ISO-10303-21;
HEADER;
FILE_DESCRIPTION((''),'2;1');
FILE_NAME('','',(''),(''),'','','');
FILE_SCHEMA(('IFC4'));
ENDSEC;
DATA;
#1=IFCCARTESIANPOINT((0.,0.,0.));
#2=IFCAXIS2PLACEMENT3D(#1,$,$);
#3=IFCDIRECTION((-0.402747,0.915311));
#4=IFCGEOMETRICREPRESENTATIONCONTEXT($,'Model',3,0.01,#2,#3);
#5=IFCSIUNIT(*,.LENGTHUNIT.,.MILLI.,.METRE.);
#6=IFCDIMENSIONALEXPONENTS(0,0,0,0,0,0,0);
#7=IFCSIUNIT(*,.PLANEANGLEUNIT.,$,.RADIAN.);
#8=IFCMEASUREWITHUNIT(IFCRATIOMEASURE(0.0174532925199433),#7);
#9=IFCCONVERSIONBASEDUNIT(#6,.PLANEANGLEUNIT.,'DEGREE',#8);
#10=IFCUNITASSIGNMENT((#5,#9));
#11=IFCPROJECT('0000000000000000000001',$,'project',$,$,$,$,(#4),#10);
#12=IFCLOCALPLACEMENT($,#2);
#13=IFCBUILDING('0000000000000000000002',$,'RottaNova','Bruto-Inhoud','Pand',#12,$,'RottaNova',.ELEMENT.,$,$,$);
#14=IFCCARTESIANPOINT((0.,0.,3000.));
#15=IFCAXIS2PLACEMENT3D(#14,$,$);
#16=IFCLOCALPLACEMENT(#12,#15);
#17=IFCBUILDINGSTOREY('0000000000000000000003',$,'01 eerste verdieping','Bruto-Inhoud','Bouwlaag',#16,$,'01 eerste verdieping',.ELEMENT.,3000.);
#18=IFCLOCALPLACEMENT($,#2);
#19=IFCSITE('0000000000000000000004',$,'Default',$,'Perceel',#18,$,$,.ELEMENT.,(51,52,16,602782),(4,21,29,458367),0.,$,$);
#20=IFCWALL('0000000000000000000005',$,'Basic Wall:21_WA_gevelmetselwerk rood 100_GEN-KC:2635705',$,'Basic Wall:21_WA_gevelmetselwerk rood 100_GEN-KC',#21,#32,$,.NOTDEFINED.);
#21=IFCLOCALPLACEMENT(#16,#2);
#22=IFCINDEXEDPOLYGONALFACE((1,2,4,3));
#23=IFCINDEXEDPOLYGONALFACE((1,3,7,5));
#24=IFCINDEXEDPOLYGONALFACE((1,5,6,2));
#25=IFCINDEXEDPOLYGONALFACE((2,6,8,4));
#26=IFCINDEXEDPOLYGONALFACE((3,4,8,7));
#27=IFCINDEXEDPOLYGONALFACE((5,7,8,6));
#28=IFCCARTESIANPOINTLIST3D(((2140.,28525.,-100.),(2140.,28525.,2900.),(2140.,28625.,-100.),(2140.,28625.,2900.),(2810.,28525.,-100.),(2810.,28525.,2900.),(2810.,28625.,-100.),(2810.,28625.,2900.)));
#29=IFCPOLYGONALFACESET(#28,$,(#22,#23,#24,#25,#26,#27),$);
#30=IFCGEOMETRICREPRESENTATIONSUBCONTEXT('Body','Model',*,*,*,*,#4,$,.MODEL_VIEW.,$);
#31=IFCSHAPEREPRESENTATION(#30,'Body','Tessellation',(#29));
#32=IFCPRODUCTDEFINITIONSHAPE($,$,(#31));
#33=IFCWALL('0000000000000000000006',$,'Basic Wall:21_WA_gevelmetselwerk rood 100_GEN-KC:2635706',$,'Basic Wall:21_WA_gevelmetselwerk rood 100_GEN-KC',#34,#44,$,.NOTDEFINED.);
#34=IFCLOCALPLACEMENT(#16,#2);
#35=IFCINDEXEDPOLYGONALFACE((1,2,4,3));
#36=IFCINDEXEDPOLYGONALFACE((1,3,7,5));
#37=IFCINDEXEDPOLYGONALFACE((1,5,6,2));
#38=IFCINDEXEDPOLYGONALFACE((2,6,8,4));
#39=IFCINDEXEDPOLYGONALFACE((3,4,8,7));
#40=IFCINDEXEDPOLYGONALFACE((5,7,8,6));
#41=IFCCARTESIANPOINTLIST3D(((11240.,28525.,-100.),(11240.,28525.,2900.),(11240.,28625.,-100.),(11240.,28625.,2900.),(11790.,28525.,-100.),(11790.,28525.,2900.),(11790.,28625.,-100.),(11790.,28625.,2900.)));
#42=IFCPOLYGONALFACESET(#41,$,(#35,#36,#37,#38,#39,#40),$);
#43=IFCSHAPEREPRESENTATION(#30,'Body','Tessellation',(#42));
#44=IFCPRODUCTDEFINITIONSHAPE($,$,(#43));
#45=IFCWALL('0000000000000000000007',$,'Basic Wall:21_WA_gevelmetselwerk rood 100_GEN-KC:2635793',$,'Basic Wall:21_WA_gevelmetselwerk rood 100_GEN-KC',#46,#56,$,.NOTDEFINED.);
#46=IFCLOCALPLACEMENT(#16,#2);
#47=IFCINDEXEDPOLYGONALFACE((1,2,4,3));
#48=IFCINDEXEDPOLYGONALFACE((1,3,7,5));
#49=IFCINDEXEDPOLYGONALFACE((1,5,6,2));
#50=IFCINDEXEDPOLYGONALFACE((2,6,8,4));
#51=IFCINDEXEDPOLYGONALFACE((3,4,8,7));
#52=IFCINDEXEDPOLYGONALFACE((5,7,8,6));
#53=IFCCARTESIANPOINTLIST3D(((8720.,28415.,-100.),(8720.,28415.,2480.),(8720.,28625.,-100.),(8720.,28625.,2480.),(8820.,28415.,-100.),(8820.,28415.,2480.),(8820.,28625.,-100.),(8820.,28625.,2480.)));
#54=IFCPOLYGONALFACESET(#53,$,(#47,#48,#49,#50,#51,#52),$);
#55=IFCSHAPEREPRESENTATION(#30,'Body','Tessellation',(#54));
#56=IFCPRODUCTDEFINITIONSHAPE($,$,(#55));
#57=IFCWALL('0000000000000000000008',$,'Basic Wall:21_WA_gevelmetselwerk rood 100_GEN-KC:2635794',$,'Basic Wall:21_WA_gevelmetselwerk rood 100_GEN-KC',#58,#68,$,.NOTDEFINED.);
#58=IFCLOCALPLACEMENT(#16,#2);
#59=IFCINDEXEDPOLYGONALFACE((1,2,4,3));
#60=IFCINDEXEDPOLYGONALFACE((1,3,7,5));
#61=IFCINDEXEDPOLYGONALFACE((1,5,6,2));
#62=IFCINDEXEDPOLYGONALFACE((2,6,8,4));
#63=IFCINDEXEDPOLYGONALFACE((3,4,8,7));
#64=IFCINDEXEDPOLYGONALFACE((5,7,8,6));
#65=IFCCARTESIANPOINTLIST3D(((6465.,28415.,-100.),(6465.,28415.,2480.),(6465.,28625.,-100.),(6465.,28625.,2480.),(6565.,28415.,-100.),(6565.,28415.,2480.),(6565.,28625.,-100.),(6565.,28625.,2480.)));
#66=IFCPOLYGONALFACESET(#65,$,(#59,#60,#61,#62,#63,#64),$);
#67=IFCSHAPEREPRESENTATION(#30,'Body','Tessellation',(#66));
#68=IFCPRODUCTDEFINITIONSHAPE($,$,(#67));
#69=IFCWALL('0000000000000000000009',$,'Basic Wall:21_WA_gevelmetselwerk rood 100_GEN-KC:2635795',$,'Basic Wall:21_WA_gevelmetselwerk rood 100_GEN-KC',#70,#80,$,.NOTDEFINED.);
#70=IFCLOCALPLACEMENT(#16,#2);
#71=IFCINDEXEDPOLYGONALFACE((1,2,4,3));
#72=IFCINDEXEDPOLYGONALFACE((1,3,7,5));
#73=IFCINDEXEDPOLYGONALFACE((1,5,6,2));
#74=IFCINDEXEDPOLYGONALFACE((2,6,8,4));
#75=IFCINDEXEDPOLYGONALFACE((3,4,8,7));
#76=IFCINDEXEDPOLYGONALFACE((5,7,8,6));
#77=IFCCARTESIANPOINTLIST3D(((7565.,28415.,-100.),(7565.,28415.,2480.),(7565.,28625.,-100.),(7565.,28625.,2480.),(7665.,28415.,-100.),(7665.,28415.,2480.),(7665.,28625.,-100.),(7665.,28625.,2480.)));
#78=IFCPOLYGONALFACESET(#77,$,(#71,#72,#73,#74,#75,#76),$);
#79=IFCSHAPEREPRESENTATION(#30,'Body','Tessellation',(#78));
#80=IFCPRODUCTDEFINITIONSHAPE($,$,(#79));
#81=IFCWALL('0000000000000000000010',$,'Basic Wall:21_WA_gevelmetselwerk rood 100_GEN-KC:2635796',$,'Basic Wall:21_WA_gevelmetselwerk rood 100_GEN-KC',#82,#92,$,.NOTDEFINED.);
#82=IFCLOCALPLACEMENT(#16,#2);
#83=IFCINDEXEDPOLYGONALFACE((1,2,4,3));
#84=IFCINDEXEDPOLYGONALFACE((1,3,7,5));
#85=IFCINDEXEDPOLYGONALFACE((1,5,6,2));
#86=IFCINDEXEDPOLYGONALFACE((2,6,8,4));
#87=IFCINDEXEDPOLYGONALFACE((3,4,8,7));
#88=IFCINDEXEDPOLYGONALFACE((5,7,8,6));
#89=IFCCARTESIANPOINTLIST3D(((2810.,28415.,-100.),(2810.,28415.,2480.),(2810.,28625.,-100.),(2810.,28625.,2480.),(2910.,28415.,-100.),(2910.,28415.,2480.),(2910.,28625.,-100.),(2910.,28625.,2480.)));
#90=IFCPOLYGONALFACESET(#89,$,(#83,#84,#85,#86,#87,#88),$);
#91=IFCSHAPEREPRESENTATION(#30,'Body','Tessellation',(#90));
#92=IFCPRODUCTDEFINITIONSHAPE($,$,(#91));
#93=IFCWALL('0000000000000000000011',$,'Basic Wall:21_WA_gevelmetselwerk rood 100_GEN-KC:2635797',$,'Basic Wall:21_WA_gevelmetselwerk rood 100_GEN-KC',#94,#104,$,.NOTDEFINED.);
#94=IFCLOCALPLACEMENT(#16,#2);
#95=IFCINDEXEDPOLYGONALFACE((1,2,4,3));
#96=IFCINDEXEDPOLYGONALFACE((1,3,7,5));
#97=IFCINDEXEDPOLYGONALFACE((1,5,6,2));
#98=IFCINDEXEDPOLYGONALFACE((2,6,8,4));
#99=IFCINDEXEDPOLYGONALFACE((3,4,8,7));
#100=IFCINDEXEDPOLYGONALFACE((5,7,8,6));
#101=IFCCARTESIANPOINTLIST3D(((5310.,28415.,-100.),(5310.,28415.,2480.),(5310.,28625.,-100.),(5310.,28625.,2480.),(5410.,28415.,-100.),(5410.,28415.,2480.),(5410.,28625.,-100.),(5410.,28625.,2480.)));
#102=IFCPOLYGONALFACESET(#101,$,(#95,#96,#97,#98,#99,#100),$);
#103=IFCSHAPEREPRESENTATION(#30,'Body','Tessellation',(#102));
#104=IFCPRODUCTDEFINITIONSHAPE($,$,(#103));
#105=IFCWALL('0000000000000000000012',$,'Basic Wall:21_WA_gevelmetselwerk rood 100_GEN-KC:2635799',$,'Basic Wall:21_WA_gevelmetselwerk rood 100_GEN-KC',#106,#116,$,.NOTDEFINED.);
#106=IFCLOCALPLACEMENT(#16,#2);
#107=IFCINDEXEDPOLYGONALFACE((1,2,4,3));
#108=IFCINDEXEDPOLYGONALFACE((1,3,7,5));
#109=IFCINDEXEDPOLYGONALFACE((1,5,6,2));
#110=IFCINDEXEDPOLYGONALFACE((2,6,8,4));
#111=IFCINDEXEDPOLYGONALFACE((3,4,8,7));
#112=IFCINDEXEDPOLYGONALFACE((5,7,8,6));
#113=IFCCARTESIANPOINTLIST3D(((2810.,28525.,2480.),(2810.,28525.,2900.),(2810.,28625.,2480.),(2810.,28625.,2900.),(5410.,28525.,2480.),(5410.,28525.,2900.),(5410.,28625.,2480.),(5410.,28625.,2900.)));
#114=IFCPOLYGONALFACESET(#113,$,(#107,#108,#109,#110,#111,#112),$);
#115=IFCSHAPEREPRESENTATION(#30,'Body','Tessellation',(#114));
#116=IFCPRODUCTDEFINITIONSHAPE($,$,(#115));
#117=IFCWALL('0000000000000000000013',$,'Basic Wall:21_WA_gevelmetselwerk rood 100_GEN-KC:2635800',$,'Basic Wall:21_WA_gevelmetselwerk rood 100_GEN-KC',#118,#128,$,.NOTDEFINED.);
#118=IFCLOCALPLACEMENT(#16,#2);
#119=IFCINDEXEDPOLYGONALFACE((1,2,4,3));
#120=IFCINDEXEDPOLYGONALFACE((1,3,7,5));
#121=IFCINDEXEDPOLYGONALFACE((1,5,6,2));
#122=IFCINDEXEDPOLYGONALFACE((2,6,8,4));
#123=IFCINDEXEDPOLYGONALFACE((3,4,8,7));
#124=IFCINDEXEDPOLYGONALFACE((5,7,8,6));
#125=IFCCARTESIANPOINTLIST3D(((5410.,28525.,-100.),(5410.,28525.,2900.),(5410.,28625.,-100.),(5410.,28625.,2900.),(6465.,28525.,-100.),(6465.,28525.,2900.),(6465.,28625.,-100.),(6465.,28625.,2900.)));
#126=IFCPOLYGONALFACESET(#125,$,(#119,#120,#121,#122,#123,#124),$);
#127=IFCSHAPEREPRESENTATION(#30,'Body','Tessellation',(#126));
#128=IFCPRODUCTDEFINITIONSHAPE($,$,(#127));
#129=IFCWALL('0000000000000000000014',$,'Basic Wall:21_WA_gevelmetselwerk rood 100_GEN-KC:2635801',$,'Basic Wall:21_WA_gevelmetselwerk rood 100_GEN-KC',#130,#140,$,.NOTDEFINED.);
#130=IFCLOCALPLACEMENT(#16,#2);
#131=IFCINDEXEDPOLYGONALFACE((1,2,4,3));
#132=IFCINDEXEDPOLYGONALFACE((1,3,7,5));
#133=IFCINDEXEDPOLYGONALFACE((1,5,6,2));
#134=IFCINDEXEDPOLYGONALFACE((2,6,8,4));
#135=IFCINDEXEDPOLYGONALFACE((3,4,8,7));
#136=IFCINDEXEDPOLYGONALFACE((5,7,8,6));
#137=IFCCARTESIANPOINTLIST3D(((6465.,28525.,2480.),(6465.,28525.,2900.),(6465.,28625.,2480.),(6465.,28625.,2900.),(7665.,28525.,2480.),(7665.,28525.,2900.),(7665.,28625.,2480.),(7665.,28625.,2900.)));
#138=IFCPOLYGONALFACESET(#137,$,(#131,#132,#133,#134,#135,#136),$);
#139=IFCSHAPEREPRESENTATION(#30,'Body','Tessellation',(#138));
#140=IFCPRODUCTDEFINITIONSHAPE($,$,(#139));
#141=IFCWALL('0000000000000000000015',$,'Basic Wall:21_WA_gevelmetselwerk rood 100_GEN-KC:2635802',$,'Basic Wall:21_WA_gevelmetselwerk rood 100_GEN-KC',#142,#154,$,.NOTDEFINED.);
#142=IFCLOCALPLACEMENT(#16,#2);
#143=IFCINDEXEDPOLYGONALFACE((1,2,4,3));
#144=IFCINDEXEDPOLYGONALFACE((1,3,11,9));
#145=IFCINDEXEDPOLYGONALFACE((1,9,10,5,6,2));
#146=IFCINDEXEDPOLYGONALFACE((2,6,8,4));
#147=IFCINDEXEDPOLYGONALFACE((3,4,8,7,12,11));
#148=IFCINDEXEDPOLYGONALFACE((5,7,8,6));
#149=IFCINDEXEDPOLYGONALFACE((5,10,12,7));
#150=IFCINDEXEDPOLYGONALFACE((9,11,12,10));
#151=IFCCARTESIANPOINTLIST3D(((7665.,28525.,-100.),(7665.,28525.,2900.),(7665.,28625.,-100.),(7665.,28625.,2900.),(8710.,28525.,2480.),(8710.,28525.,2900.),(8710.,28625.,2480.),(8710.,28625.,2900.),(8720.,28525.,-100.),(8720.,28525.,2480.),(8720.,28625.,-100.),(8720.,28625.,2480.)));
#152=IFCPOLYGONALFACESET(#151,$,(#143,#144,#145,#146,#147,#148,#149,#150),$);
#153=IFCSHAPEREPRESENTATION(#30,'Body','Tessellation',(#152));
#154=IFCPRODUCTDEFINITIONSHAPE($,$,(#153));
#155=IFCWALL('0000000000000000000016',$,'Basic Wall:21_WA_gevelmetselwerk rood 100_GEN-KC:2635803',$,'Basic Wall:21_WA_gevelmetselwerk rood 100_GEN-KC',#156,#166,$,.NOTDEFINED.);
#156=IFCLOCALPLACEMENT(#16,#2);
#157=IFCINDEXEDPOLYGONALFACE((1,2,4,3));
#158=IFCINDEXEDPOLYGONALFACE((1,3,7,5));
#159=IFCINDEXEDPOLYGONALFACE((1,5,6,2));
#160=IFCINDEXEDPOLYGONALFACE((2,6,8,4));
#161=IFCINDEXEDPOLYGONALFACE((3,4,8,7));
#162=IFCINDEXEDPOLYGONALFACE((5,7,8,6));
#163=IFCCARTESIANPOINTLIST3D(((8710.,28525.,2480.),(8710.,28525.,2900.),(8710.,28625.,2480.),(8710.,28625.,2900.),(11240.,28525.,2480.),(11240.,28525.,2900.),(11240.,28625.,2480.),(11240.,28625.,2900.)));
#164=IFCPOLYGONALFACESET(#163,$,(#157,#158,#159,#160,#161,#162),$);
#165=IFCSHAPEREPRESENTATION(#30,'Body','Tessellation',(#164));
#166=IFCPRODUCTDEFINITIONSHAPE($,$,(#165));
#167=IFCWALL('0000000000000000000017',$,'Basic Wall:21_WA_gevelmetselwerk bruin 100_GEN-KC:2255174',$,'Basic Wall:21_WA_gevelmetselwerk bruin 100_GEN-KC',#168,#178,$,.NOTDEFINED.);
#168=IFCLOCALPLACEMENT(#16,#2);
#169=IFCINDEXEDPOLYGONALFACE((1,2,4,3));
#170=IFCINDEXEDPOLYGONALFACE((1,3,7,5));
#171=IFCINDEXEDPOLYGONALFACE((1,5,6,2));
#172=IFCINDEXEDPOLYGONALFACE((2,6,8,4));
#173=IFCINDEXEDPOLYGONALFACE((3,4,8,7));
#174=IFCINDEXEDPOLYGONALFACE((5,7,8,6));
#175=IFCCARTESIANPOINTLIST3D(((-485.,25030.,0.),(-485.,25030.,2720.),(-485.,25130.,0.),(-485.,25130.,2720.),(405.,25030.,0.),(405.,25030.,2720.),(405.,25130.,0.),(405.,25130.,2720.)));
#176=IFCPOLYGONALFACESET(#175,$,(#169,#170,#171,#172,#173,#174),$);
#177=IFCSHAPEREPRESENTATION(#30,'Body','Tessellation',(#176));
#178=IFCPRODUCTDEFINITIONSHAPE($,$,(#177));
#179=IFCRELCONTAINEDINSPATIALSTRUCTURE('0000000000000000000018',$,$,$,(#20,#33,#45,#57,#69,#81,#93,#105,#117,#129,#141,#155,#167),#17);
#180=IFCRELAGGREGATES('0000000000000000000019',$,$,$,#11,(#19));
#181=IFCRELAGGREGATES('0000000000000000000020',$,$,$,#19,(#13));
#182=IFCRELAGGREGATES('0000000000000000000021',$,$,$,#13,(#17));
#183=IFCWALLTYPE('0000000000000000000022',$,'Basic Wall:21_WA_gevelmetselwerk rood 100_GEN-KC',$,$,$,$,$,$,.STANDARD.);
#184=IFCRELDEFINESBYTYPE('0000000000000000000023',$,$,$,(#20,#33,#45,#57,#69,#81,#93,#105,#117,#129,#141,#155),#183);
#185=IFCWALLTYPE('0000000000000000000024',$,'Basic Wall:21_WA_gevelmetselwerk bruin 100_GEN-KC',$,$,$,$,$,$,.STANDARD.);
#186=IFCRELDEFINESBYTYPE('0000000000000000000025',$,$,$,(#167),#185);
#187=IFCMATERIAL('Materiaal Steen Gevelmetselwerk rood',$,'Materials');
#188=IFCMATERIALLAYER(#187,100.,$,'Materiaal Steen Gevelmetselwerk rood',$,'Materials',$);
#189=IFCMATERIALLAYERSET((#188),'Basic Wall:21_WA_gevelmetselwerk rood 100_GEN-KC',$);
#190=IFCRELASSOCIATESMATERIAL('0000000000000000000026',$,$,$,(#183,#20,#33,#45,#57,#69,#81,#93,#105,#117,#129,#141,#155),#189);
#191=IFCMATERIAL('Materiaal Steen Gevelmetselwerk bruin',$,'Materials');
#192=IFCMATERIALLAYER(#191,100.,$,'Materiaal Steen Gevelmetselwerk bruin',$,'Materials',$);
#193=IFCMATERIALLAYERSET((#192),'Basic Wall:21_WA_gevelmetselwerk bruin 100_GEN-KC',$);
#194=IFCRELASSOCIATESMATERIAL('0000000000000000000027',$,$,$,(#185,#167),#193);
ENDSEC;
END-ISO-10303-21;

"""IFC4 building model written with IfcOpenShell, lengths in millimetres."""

from ifc_helpers import new_model, entity, si_unit, converted_unit, direction, frame, frame_2d, origin, place, context, subcontext, project, spatial, polyline, rectangle, extrude, clip, bounded_halfspace, material, layer, layer_set, type_object, element, save


model = new_model("IFC4")

# Units and contexts
model_context = context("Model", 3, precision=0.01, world=origin(), true_north=direction((-0.402747, 0.915311)))
body_context = subcontext(model_context, "Body", "Model", "MODEL_VIEW")
ifc_project = project(units=[si_unit("LENGTHUNIT", "METRE", prefix="MILLI"), converted_unit("PLANEANGLEUNIT", "DEGREE", entity("IfcRatioMeasure", 0.0174532925199433), si_unit("PLANEANGLEUNIT", "RADIAN"), dimensions=[0, 0, 0, 0, 0, 0, 0])], contexts=[model_context])

# Site, building, storey
site_placement = place(None, origin())
site = spatial("IfcSite", under=ifc_project, at=site_placement, Name="Default", ObjectType="Perceel", CompositionType="ELEMENT", RefLatitude=(51, 52, 16, 602782), RefLongitude=(4, 21, 29, 458367), RefElevation=0.0)
building_placement = place(None, origin())
building = spatial("IfcBuilding", under=site, at=building_placement, Name="RottaNova", Description="Bruto-Inhoud", ObjectType="Pand", LongName="RottaNova", CompositionType="ELEMENT")
storey_placement = place(building_placement, frame((0.0, 0.0, 3000.0)))
storey = spatial("IfcBuildingStorey", under=building, at=storey_placement, Name="01 eerste verdieping", Description="Bruto-Inhoud", ObjectType="Bouwlaag", LongName="01 eerste verdieping", CompositionType="ELEMENT", Elevation=3000.0)

# Walls
ifc_material_1 = material(Name="Materiaal Steen Gevelmetselwerk rood", Category="Materials")
ifc_layer_1 = layer(ifc_material_1, 100.0, Name="Materiaal Steen Gevelmetselwerk rood", Category="Materials")
ifc_layer_set_1 = layer_set([ifc_layer_1], Name="Basic Wall:21_WA_gevelmetselwerk rood 100_GEN-KC")
wall_type_1 = type_object("IfcWallType", Name="Basic Wall:21_WA_gevelmetselwerk rood 100_GEN-KC", PredefinedType="STANDARD", material=ifc_layer_set_1)
wall_1_placement = place(storey_placement, frame((2140.0, 28575.0, -100.0)))
element("IfcWall", 1, at=wall_1_placement, inside=storey, type_object=wall_type_1, material=ifc_layer_set_1, Name="Basic Wall:21_WA_gevelmetselwerk rood 100_GEN-KC:2635705", ObjectType="Basic Wall:21_WA_gevelmetselwerk rood 100_GEN-KC", PredefinedType="NOTDEFINED", context=body_context, shape_type="SweptSolid", body=[
    extrude(rectangle(XDim=670.0, YDim=100.0, at=frame_2d((335.0, 0.0), x_axis=(-1.0, 0.0))), origin(), (0.0, 0.0, 1.0), 3000.0),
])
wall_2_placement = place(storey_placement, frame((11240.0, 28575.0, -100.0)))
element("IfcWall", 2, at=wall_2_placement, inside=storey, type_object=wall_type_1, material=ifc_layer_set_1, Name="Basic Wall:21_WA_gevelmetselwerk rood 100_GEN-KC:2635706", ObjectType="Basic Wall:21_WA_gevelmetselwerk rood 100_GEN-KC", PredefinedType="NOTDEFINED", context=body_context, shape_type="SweptSolid", body=[
    extrude(rectangle(XDim=550.0, YDim=100.0, at=frame_2d((275.0, 0.0), x_axis=(-1.0, 0.0))), origin(), (0.0, 0.0, 1.0), 3000.0),
])
wall_3_placement = place(storey_placement, frame((8770.0, 28415.0, -100.0), z_axis=(0.0, 0.0, 1.0), x_axis=(0.0, 1.0, 0.0)))
element("IfcWall", 3, at=wall_3_placement, inside=storey, type_object=wall_type_1, material=ifc_layer_set_1, Name="Basic Wall:21_WA_gevelmetselwerk rood 100_GEN-KC:2635793", ObjectType="Basic Wall:21_WA_gevelmetselwerk rood 100_GEN-KC", PredefinedType="NOTDEFINED", context=body_context, shape_type="SweptSolid", body=[
    extrude(rectangle(XDim=210.0, YDim=100.0, at=frame_2d((105.0, 0.0), x_axis=(-1.0, 0.0))), origin(), (0.0, 0.0, 1.0), 2580.0),
])
for number, where, z_axis, x_axis, name in (
    (4, (6515.0, 28415.0, -100.0), (0.0, 0.0, 1.0), (0.0, 1.0, 0.0), "Basic Wall:21_WA_gevelmetselwerk rood 100_GEN-KC:2635794"),
    (5, (7615.0, 28415.0, -100.0), (0.0, 0.0, 1.0), (0.0, 1.0, 0.0), "Basic Wall:21_WA_gevelmetselwerk rood 100_GEN-KC:2635795"),
):
    element("IfcWall", number, at=place(storey_placement, frame(where, z_axis=z_axis, x_axis=x_axis)), inside=storey, type_object=wall_type_1, material=ifc_layer_set_1, Name=name, ObjectType="Basic Wall:21_WA_gevelmetselwerk rood 100_GEN-KC", PredefinedType="NOTDEFINED", context=body_context, shape_type="SweptSolid", body=[
        extrude(rectangle(XDim=210.0, YDim=100.0, at=frame_2d((105.0, 0.0), x_axis=(-1.0, 0.0))), origin(), (0.0, 0.0, 1.0), 2580.0),
    ])
wall_4_placement = place(storey_placement, frame((2860.0, 28415.0, -100.0), z_axis=(0.0, 0.0, 1.0), x_axis=(0.0, 1.0, 0.0)))
element("IfcWall", 6, at=wall_4_placement, inside=storey, type_object=wall_type_1, material=ifc_layer_set_1, Name="Basic Wall:21_WA_gevelmetselwerk rood 100_GEN-KC:2635796", ObjectType="Basic Wall:21_WA_gevelmetselwerk rood 100_GEN-KC", PredefinedType="NOTDEFINED", context=body_context, shape_type="SweptSolid", body=[
    extrude(rectangle(XDim=210.0, YDim=100.0, at=frame_2d((105.0, 0.0), x_axis=(-1.0, 0.0))), origin(), (0.0, 0.0, 1.0), 2580.0),
])
wall_5_placement = place(storey_placement, frame((5360.0, 28415.0, -100.0), z_axis=(0.0, 0.0, 1.0), x_axis=(0.0, 1.0, 0.0)))
element("IfcWall", 7, at=wall_5_placement, inside=storey, type_object=wall_type_1, material=ifc_layer_set_1, Name="Basic Wall:21_WA_gevelmetselwerk rood 100_GEN-KC:2635797", ObjectType="Basic Wall:21_WA_gevelmetselwerk rood 100_GEN-KC", PredefinedType="NOTDEFINED", context=body_context, shape_type="SweptSolid", body=[
    extrude(rectangle(XDim=210.0, YDim=100.0, at=frame_2d((105.0, 0.0), x_axis=(-1.0, 0.0))), origin(), (0.0, 0.0, 1.0), 2580.0),
])
wall_6_placement = place(storey_placement, frame((2810.0, 28575.0, 2480.0)))
element("IfcWall", 8, at=wall_6_placement, inside=storey, type_object=wall_type_1, material=ifc_layer_set_1, Name="Basic Wall:21_WA_gevelmetselwerk rood 100_GEN-KC:2635799", ObjectType="Basic Wall:21_WA_gevelmetselwerk rood 100_GEN-KC", PredefinedType="NOTDEFINED", context=body_context, shape_type="Clipping", body=[
    clip(extrude(rectangle(XDim=2600.0, YDim=100.0, at=frame_2d((1300.0, 0.0), x_axis=(-1.0, 0.0))), origin(), (0.0, 0.0, 1.0), 420.0), bounded_halfspace(frame((2600.0, -50.0, 420.0), z_axis=(1.0, 0.0, 0.0), x_axis=(0.0, 1.0, 0.0)), False, frame((2600.0, -50.0, 420.0), z_axis=(1.0, 0.0, 0.0), x_axis=(0.0, 1.0, 0.0)), polyline([(0.0, 0.0), (0.0, -128016.0), (30480.0, -128016.0), (30480.0, 0.0), (0.0, 0.0)]))),
])
wall_7_placement = place(storey_placement, frame((5410.0, 28575.0, -100.0)))
element("IfcWall", 9, at=wall_7_placement, inside=storey, type_object=wall_type_1, material=ifc_layer_set_1, Name="Basic Wall:21_WA_gevelmetselwerk rood 100_GEN-KC:2635800", ObjectType="Basic Wall:21_WA_gevelmetselwerk rood 100_GEN-KC", PredefinedType="NOTDEFINED", context=body_context, shape_type="SweptSolid", body=[
    extrude(rectangle(XDim=1055.0, YDim=100.0, at=frame_2d((527.5, 0.0), x_axis=(-1.0, 0.0))), origin(), (0.0, 0.0, 1.0), 3000.0),
])
wall_8_placement = place(storey_placement, frame((6465.0, 28575.0, 2480.0)))
element("IfcWall", 10, at=wall_8_placement, inside=storey, type_object=wall_type_1, material=ifc_layer_set_1, Name="Basic Wall:21_WA_gevelmetselwerk rood 100_GEN-KC:2635801", ObjectType="Basic Wall:21_WA_gevelmetselwerk rood 100_GEN-KC", PredefinedType="NOTDEFINED", context=body_context, shape_type="SweptSolid", body=[
    extrude(rectangle(XDim=1200.0, YDim=100.0, at=frame_2d((600.0, 0.0), x_axis=(-1.0, 0.0))), origin(), (0.0, 0.0, 1.0), 420.0),
])
wall_9_placement = place(storey_placement, frame((7665.0, 28575.0, -100.0)))
element("IfcWall", 11, at=wall_9_placement, inside=storey, type_object=wall_type_1, material=ifc_layer_set_1, Name="Basic Wall:21_WA_gevelmetselwerk rood 100_GEN-KC:2635802", ObjectType="Basic Wall:21_WA_gevelmetselwerk rood 100_GEN-KC", PredefinedType="NOTDEFINED", context=body_context, shape_type="Clipping", body=[
    clip(clip(extrude(rectangle(XDim=1055.0, YDim=100.0, at=frame_2d((527.5, 0.0), x_axis=(-1.0, 0.0))), origin(), (0.0, 0.0, 1.0), 3000.0), bounded_halfspace(frame((1045.0, 50.0, 2580.0), z_axis=(0.0, 0.0, -1.0), x_axis=(0.0, 1.0, 0.0)), True, frame((1045.0, 50.0, 2580.0), z_axis=(0.0, 0.0, -1.0), x_axis=(0.0, 1.0, 0.0)), polyline([(0.0, 0.0), (0.0, 10.0), (-100.0, 10.0), (-100.0, 0.0), (0.0, 0.0)]))), bounded_halfspace(frame((1045.0, -50.0, 2580.0), z_axis=(-1.0, 0.0, 0.0), x_axis=(0.0, 1.0, 0.0)), True, frame((1045.0, -50.0, 2580.0), z_axis=(-1.0, 0.0, 0.0), x_axis=(0.0, 1.0, 0.0)), polyline([(0.0, 0.0), (0.0, -128016.0), (30480.0, -128016.0), (30480.0, 0.0), (0.0, 0.0)]))),
])
wall_10_placement = place(storey_placement, frame((8710.0, 28575.0, 2480.0)))
element("IfcWall", 12, at=wall_10_placement, inside=storey, type_object=wall_type_1, material=ifc_layer_set_1, Name="Basic Wall:21_WA_gevelmetselwerk rood 100_GEN-KC:2635803", ObjectType="Basic Wall:21_WA_gevelmetselwerk rood 100_GEN-KC", PredefinedType="NOTDEFINED", context=body_context, shape_type="SweptSolid", body=[
    extrude(rectangle(XDim=2530.0, YDim=100.0, at=frame_2d((1265.0, 0.0), x_axis=(-1.0, 0.0))), origin(), (0.0, 0.0, 1.0), 420.0),
])
ifc_material_2 = material(Name="Materiaal Steen Gevelmetselwerk bruin", Category="Materials")
ifc_layer_2 = layer(ifc_material_2, 100.0, Name="Materiaal Steen Gevelmetselwerk bruin", Category="Materials")
ifc_layer_set_2 = layer_set([ifc_layer_2], Name="Basic Wall:21_WA_gevelmetselwerk bruin 100_GEN-KC")
wall_type_2 = type_object("IfcWallType", Name="Basic Wall:21_WA_gevelmetselwerk bruin 100_GEN-KC", PredefinedType="STANDARD", material=ifc_layer_set_2)
wall_11_placement = place(storey_placement, frame((-485.0, 25080.0, 0.0)))
element("IfcWall", 13, at=wall_11_placement, inside=storey, type_object=wall_type_2, material=ifc_layer_set_2, Name="Basic Wall:21_WA_gevelmetselwerk bruin 100_GEN-KC:2255174", ObjectType="Basic Wall:21_WA_gevelmetselwerk bruin 100_GEN-KC", PredefinedType="NOTDEFINED", context=body_context, shape_type="SweptSolid", body=[
    extrude(rectangle(XDim=890.0, YDim=100.0, at=frame_2d((445.0, 0.0), x_axis=(-1.0, 0.0))), origin(), (0.0, 0.0, 1.0), 2720.0),
])

save(model, "model.ifc")
